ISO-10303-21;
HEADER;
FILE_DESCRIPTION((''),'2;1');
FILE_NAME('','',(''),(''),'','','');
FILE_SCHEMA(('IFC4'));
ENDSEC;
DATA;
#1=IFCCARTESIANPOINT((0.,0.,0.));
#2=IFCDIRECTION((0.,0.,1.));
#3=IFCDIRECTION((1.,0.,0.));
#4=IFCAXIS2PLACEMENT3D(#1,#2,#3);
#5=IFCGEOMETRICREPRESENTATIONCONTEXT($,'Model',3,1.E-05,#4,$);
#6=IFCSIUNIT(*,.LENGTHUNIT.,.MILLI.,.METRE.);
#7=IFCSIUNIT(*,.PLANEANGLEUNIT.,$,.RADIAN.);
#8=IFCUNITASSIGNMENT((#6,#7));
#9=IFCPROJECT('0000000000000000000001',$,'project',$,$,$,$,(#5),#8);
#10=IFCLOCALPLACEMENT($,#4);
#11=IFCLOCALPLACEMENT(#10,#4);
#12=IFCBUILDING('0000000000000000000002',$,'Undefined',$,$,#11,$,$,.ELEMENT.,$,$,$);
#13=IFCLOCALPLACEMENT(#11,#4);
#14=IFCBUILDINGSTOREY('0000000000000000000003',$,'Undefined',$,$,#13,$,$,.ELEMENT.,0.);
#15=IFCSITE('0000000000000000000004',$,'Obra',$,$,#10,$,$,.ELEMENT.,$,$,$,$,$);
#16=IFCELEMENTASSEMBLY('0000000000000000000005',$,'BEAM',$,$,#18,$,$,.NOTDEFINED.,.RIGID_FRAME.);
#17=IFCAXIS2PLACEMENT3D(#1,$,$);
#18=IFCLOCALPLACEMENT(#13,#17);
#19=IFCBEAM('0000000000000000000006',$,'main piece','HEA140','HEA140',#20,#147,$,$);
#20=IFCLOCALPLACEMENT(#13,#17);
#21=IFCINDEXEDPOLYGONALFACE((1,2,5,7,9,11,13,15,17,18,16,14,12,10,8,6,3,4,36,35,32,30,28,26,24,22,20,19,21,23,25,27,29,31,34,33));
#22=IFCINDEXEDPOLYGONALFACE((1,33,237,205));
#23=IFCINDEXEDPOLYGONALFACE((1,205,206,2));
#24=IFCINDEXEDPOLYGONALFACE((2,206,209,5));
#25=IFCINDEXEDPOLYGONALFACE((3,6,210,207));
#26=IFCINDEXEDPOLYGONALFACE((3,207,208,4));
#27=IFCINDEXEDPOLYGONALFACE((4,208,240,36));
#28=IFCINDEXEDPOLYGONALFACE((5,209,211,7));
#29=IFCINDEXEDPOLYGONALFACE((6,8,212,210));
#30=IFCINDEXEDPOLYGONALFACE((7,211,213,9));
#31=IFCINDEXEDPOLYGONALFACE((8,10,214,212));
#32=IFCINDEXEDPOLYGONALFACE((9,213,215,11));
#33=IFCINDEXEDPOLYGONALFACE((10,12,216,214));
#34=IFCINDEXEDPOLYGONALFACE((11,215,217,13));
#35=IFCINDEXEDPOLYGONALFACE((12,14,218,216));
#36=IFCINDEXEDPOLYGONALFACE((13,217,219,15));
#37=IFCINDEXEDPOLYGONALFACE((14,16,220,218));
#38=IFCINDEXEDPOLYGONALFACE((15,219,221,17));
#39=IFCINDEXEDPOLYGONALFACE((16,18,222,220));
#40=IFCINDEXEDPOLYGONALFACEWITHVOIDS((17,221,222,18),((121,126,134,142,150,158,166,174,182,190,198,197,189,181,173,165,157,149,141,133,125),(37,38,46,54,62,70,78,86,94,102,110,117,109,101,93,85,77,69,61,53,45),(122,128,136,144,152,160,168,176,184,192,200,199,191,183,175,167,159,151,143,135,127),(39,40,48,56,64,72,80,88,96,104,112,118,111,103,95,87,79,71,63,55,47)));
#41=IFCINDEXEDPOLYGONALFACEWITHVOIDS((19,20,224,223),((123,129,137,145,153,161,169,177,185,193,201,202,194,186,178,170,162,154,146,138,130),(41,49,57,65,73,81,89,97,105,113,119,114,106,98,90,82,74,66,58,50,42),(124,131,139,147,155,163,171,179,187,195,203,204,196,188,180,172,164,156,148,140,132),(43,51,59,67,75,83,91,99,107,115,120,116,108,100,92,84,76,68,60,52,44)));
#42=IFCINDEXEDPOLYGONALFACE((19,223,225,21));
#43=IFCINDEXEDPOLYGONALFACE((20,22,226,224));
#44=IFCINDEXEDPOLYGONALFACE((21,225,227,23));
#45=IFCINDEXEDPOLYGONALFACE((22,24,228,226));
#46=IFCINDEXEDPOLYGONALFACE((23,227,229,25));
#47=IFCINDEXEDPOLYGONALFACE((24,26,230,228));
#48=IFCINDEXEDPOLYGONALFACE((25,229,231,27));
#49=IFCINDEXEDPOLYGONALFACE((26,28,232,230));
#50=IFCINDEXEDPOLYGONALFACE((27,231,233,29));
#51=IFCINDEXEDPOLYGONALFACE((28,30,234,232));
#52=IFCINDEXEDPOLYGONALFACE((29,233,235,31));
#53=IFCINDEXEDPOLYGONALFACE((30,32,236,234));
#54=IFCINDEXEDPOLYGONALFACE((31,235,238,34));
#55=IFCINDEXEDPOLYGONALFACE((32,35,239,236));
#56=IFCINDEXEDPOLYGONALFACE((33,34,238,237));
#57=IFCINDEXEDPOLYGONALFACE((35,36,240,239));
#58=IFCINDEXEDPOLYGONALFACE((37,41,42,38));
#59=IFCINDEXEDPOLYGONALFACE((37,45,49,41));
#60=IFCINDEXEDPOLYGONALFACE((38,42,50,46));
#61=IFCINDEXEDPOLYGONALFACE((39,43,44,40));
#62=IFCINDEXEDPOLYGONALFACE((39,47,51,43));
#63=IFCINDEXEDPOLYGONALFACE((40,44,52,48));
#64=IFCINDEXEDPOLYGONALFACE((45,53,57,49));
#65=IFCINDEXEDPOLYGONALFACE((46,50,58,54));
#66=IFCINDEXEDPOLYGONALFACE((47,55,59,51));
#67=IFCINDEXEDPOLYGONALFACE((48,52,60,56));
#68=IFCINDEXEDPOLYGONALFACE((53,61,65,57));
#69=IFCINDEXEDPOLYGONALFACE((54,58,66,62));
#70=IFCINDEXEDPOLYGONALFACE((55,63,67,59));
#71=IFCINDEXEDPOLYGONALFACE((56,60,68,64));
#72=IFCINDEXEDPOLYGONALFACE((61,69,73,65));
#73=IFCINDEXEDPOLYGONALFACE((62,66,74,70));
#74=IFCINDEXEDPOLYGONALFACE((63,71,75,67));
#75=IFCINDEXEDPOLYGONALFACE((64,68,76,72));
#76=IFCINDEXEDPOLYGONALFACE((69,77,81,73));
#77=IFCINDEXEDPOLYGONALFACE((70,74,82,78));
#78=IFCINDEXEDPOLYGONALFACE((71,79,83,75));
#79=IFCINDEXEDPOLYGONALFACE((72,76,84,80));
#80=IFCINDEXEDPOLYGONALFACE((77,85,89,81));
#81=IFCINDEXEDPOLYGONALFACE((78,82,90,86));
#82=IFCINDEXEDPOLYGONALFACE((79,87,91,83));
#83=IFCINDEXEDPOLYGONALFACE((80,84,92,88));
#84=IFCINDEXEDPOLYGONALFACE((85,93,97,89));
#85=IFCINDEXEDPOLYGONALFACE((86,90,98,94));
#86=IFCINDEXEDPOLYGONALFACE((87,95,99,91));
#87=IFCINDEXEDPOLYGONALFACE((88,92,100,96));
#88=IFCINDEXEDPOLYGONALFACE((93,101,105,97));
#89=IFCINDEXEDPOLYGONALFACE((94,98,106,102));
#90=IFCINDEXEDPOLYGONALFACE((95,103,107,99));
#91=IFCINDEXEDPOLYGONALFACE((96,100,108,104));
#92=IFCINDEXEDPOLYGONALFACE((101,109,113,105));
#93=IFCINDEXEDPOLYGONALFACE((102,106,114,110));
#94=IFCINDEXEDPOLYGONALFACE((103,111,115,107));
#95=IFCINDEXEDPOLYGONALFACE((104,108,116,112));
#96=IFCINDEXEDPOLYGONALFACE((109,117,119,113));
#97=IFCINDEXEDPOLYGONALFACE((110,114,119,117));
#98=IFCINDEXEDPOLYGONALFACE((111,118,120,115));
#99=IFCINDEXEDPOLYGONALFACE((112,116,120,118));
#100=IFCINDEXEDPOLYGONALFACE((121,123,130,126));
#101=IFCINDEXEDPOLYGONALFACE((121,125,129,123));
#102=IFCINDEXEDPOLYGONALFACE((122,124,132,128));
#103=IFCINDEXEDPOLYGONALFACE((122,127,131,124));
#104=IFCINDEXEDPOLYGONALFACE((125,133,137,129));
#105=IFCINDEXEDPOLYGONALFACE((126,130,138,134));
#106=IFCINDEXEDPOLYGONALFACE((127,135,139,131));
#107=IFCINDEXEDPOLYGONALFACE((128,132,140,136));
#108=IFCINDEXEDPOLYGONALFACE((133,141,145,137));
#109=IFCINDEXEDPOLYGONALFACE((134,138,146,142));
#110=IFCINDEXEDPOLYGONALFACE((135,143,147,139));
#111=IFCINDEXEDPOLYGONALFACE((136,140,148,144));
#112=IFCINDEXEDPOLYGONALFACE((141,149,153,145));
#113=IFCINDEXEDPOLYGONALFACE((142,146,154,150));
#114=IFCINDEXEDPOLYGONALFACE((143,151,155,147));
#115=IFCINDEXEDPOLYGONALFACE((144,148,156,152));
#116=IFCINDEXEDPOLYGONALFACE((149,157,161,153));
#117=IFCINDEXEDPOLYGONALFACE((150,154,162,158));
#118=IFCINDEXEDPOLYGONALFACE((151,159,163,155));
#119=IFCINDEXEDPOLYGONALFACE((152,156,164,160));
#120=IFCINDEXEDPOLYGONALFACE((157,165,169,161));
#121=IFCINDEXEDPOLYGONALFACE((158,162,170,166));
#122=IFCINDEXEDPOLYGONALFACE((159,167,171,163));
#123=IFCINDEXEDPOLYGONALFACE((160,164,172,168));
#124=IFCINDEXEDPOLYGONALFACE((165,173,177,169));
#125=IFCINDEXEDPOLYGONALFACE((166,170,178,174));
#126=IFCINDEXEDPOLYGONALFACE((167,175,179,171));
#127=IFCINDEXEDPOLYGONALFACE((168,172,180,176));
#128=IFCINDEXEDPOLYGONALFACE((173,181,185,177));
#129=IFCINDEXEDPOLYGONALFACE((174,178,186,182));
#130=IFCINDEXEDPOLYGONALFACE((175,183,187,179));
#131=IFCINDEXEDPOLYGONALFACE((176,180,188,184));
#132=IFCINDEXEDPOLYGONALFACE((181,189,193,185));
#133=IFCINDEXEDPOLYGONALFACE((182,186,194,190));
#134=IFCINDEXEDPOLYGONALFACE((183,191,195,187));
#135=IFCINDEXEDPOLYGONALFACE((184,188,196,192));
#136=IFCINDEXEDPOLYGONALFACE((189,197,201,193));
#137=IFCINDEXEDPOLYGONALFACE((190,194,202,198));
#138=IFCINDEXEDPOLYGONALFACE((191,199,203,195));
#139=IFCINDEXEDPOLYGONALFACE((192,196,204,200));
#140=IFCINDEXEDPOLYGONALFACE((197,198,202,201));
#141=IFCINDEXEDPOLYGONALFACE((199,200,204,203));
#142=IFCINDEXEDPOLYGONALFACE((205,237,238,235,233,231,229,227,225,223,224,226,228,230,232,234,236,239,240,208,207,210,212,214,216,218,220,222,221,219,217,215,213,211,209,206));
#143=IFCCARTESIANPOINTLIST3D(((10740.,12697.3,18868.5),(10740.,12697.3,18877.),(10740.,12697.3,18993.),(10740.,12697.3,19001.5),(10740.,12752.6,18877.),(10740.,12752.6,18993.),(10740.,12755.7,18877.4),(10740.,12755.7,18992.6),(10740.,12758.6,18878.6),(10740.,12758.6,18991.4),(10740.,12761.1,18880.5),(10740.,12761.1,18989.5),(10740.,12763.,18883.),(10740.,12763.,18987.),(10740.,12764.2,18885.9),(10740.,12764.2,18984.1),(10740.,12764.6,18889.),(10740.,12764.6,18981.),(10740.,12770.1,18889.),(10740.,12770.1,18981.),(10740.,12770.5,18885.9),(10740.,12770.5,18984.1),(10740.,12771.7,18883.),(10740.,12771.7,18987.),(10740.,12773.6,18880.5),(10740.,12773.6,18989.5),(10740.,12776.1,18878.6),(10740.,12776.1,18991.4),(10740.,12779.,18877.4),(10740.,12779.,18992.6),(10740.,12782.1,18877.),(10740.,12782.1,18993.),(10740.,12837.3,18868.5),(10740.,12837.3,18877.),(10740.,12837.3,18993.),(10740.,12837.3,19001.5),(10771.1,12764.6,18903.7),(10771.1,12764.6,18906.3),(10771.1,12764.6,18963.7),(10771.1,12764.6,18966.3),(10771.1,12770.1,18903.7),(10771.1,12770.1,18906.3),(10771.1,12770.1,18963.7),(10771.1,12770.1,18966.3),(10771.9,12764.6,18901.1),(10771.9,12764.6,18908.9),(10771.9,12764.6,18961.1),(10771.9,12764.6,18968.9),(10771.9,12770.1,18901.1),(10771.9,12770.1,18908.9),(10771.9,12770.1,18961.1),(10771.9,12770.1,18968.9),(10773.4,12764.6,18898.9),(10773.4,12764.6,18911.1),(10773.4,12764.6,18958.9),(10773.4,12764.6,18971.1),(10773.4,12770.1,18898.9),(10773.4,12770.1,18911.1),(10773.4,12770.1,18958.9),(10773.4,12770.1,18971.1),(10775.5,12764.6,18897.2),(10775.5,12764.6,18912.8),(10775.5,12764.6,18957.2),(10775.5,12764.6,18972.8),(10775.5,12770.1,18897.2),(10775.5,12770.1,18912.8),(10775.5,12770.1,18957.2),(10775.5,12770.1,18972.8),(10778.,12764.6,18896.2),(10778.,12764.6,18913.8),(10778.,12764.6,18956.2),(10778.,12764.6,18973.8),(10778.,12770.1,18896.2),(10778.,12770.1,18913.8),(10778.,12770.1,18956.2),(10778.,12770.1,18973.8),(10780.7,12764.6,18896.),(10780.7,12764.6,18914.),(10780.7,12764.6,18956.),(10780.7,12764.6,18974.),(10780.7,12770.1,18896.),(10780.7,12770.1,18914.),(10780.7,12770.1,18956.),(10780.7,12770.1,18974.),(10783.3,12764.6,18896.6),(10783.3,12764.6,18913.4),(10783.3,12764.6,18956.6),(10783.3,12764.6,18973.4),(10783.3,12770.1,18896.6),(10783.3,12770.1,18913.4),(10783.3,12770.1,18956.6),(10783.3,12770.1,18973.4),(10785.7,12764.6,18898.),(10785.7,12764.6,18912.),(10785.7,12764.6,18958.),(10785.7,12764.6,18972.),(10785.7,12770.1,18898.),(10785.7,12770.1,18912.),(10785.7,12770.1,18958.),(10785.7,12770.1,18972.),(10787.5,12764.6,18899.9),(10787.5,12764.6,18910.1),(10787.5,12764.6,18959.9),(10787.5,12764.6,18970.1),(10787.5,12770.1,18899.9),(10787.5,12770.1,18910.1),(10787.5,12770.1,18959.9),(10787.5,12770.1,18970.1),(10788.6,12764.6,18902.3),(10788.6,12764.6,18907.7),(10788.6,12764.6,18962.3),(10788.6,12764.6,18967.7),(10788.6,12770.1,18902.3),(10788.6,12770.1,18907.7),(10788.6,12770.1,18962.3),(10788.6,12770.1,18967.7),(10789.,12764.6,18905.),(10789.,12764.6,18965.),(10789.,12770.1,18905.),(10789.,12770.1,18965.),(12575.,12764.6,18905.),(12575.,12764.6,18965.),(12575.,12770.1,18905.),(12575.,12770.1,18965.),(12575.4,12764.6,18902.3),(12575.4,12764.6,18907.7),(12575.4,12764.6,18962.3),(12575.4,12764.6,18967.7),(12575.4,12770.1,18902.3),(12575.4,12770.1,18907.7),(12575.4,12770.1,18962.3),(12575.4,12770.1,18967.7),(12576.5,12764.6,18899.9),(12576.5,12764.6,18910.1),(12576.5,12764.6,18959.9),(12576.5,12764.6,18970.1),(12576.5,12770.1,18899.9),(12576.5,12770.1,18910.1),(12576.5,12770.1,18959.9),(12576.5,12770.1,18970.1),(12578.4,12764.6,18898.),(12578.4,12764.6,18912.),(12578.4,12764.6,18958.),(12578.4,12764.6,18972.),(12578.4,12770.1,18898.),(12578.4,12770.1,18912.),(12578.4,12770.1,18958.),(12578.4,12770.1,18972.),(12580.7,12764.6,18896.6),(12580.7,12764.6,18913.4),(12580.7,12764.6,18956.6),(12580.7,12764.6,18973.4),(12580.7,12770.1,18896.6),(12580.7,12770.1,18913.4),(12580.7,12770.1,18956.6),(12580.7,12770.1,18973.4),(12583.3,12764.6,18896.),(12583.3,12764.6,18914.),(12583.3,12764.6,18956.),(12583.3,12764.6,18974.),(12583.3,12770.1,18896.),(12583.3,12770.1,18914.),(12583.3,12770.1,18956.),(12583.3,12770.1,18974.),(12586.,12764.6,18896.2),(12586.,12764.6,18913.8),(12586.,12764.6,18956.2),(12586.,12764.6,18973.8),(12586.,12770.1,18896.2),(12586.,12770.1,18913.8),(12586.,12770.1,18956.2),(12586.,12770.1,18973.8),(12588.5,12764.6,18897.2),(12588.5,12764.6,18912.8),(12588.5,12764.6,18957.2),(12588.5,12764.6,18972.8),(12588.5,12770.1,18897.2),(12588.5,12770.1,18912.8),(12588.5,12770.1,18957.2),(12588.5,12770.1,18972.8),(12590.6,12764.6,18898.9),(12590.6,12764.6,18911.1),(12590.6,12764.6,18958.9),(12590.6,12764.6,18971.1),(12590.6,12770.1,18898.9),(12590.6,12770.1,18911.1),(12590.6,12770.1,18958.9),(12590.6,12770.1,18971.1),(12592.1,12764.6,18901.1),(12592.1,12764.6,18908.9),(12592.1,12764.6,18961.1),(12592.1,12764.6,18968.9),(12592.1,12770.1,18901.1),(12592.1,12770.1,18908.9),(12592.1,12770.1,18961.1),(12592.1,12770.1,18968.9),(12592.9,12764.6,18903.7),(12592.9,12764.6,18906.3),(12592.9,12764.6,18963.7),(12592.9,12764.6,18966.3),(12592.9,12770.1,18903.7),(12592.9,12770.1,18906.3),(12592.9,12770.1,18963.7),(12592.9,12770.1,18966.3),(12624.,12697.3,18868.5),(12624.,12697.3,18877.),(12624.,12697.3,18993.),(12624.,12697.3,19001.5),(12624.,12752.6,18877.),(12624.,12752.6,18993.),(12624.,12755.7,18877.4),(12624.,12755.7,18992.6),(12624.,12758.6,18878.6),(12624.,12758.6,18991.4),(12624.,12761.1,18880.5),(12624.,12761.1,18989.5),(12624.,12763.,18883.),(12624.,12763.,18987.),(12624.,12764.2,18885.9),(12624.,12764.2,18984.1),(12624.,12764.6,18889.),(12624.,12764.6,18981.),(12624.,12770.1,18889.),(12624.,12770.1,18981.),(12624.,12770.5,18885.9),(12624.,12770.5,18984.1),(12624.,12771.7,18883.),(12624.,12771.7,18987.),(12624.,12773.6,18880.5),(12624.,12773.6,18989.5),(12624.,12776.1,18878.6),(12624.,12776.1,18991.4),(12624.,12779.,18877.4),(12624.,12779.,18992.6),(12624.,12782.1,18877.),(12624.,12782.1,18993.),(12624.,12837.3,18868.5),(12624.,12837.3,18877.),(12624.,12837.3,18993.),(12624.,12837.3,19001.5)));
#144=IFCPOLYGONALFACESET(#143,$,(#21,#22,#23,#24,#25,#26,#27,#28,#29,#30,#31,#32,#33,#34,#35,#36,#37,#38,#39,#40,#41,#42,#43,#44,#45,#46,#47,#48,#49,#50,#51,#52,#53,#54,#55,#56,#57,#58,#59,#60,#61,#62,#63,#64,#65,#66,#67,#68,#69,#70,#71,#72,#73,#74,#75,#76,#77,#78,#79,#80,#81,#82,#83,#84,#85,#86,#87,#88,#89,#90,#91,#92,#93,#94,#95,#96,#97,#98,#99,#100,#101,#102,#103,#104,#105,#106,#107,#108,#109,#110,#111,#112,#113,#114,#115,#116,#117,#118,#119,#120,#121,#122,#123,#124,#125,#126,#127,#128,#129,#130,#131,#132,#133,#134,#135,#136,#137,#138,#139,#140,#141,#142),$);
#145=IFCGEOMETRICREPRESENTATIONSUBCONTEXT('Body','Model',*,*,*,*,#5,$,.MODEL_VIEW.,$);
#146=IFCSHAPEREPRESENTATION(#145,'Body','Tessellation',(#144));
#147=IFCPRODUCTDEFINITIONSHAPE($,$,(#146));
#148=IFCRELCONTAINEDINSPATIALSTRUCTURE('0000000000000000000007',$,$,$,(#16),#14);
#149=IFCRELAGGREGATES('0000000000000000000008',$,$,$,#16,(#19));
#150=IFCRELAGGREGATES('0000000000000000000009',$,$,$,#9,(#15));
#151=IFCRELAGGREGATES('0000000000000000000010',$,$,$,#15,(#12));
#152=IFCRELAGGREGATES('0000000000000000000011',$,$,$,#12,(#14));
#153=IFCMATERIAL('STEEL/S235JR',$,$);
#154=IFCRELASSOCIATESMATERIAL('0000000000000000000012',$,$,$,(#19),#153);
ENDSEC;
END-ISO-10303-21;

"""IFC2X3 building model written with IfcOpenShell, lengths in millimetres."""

from ifc_helpers import new_model, si_unit, frame, origin_with_axes, origin_2d_with_axis, place, context, subcontext, project, spatial, circle, i_section, extrude, clip, halfspace, source, transform, mapped, material, element, aggregate, save


model = new_model("IFC2X3")

# Units and contexts
model_context = context("Model", 3, precision=1e-05, world=origin_with_axes())
body_context = subcontext(model_context, "Body", "Model", "MODEL_VIEW")
ifc_project = project(units=[si_unit("LENGTHUNIT", "METRE", prefix="MILLI"), si_unit("PLANEANGLEUNIT", "RADIAN")], contexts=[model_context])

# Site, building, storey
site_placement = place(None, origin_with_axes())
site = spatial("IfcSite", under=ifc_project, at=site_placement, Name="Obra", CompositionType="ELEMENT")
building_placement = place(site_placement, origin_with_axes())
building = spatial("IfcBuilding", under=site, at=building_placement, Name="Undefined", CompositionType="ELEMENT")
storey_placement = place(building_placement, origin_with_axes())
storey = spatial("IfcBuildingStorey", under=building, at=storey_placement, Name="Undefined", CompositionType="ELEMENT", Elevation=0.0)

# Element assembly, beam, openings
ifc_material_1 = material(Name="STEEL/S235JR")
shared_shape_1 = source(origin_with_axes(), body_context, "Body", "SweptSolid", [
    extrude(circle(Radius=9.0, at=origin_2d_with_axis()), frame((0.0, -0.1, 0.0), z_axis=(0.0, 1.0, 0.0), x_axis=(1.0, 0.0, 0.0)), (0.0, 0.0, 1.0), 5.7),
])
assembly_1_placement = place(storey_placement, origin_with_axes())
assembly_1 = element("IfcElementAssembly", 1, at=assembly_1_placement, inside=storey, Name="BEAM", AssemblyPlace="NOTDEFINED", PredefinedType="RIGID_FRAME")
beam_1_placement = place(assembly_1_placement, frame((12750.0, 12767.3, 18935.0), z_axis=(0.0, 0.0, 1.0), x_axis=(-1.0, 0.0, 0.0)))
beam_1 = element("IfcBeam", 2, at=beam_1_placement, material=ifc_material_1, Name="main piece", Description="HEA140", ObjectType="HEA140", context=body_context, shape_type="Clipping", body=[
    clip(clip(extrude(i_section(OverallWidth=140.0, OverallDepth=133.0, WebThickness=5.5, FlangeThickness=8.5, FilletRadius=12.0, at=origin_2d_with_axis()), frame((2125.0, 0.0, 0.0), z_axis=(-1.0, 0.0, 0.0), x_axis=(0.0, -1.0, 0.0)), (0.0, 0.0, 1.0), 2125.0), halfspace(frame((126.0, 70.0, -66.5), z_axis=(-1.0, 0.0, 0.0), x_axis=(0.0, 0.0, 1.0)), False)), halfspace(frame((2010.0, 70.0, -66.5), z_axis=(1.0, 0.0, 0.0), x_axis=(0.0, -1.0, 0.0)), False)),
])
opening_1_placement = place(assembly_1_placement, frame((12584.0, 12770.1, 18935.0), z_axis=(0.0, 0.0, 1.0), x_axis=(-1.0, 0.0, 0.0)))
element("IfcOpeningElement", 3, at=opening_1_placement, cuts=beam_1, ObjectType="Opening", context=body_context, shape_type="MappedRepresentation", body=[
    mapped(shared_shape_1, transform((0.0, 0.0, -30.0))),
    mapped(shared_shape_1, transform((0.0, 0.0, 30.0))),
])
opening_2_placement = place(assembly_1_placement, frame((10780.0, 12770.1, 18935.0), z_axis=(0.0, 0.0, -1.0), x_axis=(1.0, 0.0, 0.0)))
element("IfcOpeningElement", 4, at=opening_2_placement, cuts=beam_1, ObjectType="Opening", context=body_context, shape_type="MappedRepresentation", body=[
    mapped(shared_shape_1, transform((0.0, 0.0, 30.0))),
    mapped(shared_shape_1, transform((0.0, 0.0, -30.0))),
])
aggregate(assembly_1, [beam_1])

save(model, "model.ifc")
